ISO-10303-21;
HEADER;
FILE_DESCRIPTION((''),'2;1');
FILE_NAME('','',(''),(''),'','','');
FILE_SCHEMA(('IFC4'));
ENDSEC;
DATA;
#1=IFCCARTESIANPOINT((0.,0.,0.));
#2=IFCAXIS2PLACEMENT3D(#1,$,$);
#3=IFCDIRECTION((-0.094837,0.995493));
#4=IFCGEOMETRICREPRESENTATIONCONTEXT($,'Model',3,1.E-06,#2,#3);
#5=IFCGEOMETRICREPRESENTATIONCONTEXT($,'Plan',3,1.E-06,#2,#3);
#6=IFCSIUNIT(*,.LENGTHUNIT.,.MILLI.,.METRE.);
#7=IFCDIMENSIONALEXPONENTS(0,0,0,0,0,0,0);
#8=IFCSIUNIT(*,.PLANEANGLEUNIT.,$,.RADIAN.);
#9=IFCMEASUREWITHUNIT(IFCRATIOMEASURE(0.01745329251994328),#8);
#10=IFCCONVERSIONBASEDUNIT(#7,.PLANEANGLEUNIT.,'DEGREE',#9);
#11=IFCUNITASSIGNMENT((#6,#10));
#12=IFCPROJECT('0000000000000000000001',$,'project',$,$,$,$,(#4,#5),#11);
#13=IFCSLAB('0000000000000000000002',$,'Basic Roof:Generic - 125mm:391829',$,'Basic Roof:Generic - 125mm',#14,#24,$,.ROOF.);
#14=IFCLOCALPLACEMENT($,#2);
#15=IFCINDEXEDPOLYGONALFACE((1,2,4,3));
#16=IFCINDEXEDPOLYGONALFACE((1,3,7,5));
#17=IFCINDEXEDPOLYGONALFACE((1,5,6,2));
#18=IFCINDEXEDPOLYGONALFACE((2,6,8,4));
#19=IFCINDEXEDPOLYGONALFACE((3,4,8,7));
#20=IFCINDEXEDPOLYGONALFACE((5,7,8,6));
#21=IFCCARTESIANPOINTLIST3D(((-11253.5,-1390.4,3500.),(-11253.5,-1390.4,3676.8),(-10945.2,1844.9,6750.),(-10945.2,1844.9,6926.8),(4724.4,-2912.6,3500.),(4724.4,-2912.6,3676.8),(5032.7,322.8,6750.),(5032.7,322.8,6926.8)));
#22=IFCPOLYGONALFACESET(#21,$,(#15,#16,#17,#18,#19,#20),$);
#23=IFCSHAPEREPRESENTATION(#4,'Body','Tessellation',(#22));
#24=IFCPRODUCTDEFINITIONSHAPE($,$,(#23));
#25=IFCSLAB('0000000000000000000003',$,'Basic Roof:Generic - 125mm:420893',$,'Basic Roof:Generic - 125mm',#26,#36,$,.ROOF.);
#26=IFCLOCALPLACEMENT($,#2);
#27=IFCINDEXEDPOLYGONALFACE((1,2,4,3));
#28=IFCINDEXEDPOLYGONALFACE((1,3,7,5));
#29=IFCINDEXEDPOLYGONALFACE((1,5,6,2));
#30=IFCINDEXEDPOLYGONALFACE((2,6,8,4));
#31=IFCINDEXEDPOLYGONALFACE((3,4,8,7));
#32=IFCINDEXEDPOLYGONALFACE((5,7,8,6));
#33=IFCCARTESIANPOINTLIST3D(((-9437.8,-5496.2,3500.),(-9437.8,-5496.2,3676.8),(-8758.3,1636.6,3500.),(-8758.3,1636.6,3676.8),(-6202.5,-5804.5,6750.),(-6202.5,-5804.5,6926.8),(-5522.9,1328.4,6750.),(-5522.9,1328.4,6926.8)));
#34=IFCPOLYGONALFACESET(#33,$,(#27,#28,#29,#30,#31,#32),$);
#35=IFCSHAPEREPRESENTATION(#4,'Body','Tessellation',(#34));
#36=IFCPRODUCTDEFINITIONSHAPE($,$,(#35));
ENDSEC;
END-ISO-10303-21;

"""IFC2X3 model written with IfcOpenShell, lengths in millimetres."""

from ifc_helpers import new_model, entity, si_unit, converted_unit, direction, frame, frame_2d, origin, place, context, project, rectangle, extrude, element, save


model = new_model("IFC2X3")

# Units and contexts
model_context = context("Model", 3, precision=1e-06, world=origin(), true_north=direction((-0.094837, 0.995493)))
plan_context = context("Plan", 3, precision=1e-06, world=origin(), true_north=direction((-0.094837, 0.995493)))
ifc_project = project(units=[si_unit("LENGTHUNIT", "METRE", prefix="MILLI"), converted_unit("PLANEANGLEUNIT", "DEGREE", entity("IfcRatioMeasure", 0.01745329251994328), si_unit("PLANEANGLEUNIT", "RADIAN"), dimensions=[0, 0, 0, 0, 0, 0, 0])], contexts=[model_context, plan_context])

# Slabs
placement_1 = place(None, frame((0.0, 0.0, 0.0), z_axis=(0.0, 0.0, 1.0), x_axis=(0.995493, -0.094837, 0.0)))
placement_2 = place(placement_1, origin())
placement_3 = place(placement_2, frame((0.0, 0.0, 3000.0)))
placement_4 = place(placement_3, origin())
slab_1_placement = place(placement_4, frame((-11070.9, -2451.4, 500.0)))
element("IfcSlab", 1, at=slab_1_placement, Name="Basic Roof:Generic - 125mm:391829", ObjectType="Basic Roof:Generic - 125mm", PredefinedType="ROOF", context=model_context, shape_type="SweptSolid", body=[
    extrude(rectangle(XDim=4596.2, YDim=16050.2, at=frame_2d((0.0, 0.0), x_axis=(0.0, 1.0))), frame((8025.1, 1625.0, 1625.0), z_axis=(0.0, -0.707107, 0.707107), x_axis=(1.0, 0.0, 0.0)), (0.0, 0.707107, 0.707107), 176.8),
])
placement_5 = place(placement_3, origin())
slab_2_placement = place(placement_5, frame((-8874.0, -6366.5, 500.0)))
element("IfcSlab", 2, at=slab_2_placement, Name="Basic Roof:Generic - 125mm:420893", ObjectType="Basic Roof:Generic - 125mm", PredefinedType="ROOF", context=model_context, shape_type="SweptSolid", body=[
    extrude(rectangle(XDim=4596.2, YDim=7165.1, at=frame_2d((0.0, 0.0), x_axis=(-1.0, 0.0))), frame((1625.0, 3582.6, 1625.0), z_axis=(-0.707107, 0.0, 0.707107), x_axis=(0.707107, 0.0, 0.707107)), (0.707107, 0.0, 0.707107), 176.8),
])

save(model, "model.ifc")
